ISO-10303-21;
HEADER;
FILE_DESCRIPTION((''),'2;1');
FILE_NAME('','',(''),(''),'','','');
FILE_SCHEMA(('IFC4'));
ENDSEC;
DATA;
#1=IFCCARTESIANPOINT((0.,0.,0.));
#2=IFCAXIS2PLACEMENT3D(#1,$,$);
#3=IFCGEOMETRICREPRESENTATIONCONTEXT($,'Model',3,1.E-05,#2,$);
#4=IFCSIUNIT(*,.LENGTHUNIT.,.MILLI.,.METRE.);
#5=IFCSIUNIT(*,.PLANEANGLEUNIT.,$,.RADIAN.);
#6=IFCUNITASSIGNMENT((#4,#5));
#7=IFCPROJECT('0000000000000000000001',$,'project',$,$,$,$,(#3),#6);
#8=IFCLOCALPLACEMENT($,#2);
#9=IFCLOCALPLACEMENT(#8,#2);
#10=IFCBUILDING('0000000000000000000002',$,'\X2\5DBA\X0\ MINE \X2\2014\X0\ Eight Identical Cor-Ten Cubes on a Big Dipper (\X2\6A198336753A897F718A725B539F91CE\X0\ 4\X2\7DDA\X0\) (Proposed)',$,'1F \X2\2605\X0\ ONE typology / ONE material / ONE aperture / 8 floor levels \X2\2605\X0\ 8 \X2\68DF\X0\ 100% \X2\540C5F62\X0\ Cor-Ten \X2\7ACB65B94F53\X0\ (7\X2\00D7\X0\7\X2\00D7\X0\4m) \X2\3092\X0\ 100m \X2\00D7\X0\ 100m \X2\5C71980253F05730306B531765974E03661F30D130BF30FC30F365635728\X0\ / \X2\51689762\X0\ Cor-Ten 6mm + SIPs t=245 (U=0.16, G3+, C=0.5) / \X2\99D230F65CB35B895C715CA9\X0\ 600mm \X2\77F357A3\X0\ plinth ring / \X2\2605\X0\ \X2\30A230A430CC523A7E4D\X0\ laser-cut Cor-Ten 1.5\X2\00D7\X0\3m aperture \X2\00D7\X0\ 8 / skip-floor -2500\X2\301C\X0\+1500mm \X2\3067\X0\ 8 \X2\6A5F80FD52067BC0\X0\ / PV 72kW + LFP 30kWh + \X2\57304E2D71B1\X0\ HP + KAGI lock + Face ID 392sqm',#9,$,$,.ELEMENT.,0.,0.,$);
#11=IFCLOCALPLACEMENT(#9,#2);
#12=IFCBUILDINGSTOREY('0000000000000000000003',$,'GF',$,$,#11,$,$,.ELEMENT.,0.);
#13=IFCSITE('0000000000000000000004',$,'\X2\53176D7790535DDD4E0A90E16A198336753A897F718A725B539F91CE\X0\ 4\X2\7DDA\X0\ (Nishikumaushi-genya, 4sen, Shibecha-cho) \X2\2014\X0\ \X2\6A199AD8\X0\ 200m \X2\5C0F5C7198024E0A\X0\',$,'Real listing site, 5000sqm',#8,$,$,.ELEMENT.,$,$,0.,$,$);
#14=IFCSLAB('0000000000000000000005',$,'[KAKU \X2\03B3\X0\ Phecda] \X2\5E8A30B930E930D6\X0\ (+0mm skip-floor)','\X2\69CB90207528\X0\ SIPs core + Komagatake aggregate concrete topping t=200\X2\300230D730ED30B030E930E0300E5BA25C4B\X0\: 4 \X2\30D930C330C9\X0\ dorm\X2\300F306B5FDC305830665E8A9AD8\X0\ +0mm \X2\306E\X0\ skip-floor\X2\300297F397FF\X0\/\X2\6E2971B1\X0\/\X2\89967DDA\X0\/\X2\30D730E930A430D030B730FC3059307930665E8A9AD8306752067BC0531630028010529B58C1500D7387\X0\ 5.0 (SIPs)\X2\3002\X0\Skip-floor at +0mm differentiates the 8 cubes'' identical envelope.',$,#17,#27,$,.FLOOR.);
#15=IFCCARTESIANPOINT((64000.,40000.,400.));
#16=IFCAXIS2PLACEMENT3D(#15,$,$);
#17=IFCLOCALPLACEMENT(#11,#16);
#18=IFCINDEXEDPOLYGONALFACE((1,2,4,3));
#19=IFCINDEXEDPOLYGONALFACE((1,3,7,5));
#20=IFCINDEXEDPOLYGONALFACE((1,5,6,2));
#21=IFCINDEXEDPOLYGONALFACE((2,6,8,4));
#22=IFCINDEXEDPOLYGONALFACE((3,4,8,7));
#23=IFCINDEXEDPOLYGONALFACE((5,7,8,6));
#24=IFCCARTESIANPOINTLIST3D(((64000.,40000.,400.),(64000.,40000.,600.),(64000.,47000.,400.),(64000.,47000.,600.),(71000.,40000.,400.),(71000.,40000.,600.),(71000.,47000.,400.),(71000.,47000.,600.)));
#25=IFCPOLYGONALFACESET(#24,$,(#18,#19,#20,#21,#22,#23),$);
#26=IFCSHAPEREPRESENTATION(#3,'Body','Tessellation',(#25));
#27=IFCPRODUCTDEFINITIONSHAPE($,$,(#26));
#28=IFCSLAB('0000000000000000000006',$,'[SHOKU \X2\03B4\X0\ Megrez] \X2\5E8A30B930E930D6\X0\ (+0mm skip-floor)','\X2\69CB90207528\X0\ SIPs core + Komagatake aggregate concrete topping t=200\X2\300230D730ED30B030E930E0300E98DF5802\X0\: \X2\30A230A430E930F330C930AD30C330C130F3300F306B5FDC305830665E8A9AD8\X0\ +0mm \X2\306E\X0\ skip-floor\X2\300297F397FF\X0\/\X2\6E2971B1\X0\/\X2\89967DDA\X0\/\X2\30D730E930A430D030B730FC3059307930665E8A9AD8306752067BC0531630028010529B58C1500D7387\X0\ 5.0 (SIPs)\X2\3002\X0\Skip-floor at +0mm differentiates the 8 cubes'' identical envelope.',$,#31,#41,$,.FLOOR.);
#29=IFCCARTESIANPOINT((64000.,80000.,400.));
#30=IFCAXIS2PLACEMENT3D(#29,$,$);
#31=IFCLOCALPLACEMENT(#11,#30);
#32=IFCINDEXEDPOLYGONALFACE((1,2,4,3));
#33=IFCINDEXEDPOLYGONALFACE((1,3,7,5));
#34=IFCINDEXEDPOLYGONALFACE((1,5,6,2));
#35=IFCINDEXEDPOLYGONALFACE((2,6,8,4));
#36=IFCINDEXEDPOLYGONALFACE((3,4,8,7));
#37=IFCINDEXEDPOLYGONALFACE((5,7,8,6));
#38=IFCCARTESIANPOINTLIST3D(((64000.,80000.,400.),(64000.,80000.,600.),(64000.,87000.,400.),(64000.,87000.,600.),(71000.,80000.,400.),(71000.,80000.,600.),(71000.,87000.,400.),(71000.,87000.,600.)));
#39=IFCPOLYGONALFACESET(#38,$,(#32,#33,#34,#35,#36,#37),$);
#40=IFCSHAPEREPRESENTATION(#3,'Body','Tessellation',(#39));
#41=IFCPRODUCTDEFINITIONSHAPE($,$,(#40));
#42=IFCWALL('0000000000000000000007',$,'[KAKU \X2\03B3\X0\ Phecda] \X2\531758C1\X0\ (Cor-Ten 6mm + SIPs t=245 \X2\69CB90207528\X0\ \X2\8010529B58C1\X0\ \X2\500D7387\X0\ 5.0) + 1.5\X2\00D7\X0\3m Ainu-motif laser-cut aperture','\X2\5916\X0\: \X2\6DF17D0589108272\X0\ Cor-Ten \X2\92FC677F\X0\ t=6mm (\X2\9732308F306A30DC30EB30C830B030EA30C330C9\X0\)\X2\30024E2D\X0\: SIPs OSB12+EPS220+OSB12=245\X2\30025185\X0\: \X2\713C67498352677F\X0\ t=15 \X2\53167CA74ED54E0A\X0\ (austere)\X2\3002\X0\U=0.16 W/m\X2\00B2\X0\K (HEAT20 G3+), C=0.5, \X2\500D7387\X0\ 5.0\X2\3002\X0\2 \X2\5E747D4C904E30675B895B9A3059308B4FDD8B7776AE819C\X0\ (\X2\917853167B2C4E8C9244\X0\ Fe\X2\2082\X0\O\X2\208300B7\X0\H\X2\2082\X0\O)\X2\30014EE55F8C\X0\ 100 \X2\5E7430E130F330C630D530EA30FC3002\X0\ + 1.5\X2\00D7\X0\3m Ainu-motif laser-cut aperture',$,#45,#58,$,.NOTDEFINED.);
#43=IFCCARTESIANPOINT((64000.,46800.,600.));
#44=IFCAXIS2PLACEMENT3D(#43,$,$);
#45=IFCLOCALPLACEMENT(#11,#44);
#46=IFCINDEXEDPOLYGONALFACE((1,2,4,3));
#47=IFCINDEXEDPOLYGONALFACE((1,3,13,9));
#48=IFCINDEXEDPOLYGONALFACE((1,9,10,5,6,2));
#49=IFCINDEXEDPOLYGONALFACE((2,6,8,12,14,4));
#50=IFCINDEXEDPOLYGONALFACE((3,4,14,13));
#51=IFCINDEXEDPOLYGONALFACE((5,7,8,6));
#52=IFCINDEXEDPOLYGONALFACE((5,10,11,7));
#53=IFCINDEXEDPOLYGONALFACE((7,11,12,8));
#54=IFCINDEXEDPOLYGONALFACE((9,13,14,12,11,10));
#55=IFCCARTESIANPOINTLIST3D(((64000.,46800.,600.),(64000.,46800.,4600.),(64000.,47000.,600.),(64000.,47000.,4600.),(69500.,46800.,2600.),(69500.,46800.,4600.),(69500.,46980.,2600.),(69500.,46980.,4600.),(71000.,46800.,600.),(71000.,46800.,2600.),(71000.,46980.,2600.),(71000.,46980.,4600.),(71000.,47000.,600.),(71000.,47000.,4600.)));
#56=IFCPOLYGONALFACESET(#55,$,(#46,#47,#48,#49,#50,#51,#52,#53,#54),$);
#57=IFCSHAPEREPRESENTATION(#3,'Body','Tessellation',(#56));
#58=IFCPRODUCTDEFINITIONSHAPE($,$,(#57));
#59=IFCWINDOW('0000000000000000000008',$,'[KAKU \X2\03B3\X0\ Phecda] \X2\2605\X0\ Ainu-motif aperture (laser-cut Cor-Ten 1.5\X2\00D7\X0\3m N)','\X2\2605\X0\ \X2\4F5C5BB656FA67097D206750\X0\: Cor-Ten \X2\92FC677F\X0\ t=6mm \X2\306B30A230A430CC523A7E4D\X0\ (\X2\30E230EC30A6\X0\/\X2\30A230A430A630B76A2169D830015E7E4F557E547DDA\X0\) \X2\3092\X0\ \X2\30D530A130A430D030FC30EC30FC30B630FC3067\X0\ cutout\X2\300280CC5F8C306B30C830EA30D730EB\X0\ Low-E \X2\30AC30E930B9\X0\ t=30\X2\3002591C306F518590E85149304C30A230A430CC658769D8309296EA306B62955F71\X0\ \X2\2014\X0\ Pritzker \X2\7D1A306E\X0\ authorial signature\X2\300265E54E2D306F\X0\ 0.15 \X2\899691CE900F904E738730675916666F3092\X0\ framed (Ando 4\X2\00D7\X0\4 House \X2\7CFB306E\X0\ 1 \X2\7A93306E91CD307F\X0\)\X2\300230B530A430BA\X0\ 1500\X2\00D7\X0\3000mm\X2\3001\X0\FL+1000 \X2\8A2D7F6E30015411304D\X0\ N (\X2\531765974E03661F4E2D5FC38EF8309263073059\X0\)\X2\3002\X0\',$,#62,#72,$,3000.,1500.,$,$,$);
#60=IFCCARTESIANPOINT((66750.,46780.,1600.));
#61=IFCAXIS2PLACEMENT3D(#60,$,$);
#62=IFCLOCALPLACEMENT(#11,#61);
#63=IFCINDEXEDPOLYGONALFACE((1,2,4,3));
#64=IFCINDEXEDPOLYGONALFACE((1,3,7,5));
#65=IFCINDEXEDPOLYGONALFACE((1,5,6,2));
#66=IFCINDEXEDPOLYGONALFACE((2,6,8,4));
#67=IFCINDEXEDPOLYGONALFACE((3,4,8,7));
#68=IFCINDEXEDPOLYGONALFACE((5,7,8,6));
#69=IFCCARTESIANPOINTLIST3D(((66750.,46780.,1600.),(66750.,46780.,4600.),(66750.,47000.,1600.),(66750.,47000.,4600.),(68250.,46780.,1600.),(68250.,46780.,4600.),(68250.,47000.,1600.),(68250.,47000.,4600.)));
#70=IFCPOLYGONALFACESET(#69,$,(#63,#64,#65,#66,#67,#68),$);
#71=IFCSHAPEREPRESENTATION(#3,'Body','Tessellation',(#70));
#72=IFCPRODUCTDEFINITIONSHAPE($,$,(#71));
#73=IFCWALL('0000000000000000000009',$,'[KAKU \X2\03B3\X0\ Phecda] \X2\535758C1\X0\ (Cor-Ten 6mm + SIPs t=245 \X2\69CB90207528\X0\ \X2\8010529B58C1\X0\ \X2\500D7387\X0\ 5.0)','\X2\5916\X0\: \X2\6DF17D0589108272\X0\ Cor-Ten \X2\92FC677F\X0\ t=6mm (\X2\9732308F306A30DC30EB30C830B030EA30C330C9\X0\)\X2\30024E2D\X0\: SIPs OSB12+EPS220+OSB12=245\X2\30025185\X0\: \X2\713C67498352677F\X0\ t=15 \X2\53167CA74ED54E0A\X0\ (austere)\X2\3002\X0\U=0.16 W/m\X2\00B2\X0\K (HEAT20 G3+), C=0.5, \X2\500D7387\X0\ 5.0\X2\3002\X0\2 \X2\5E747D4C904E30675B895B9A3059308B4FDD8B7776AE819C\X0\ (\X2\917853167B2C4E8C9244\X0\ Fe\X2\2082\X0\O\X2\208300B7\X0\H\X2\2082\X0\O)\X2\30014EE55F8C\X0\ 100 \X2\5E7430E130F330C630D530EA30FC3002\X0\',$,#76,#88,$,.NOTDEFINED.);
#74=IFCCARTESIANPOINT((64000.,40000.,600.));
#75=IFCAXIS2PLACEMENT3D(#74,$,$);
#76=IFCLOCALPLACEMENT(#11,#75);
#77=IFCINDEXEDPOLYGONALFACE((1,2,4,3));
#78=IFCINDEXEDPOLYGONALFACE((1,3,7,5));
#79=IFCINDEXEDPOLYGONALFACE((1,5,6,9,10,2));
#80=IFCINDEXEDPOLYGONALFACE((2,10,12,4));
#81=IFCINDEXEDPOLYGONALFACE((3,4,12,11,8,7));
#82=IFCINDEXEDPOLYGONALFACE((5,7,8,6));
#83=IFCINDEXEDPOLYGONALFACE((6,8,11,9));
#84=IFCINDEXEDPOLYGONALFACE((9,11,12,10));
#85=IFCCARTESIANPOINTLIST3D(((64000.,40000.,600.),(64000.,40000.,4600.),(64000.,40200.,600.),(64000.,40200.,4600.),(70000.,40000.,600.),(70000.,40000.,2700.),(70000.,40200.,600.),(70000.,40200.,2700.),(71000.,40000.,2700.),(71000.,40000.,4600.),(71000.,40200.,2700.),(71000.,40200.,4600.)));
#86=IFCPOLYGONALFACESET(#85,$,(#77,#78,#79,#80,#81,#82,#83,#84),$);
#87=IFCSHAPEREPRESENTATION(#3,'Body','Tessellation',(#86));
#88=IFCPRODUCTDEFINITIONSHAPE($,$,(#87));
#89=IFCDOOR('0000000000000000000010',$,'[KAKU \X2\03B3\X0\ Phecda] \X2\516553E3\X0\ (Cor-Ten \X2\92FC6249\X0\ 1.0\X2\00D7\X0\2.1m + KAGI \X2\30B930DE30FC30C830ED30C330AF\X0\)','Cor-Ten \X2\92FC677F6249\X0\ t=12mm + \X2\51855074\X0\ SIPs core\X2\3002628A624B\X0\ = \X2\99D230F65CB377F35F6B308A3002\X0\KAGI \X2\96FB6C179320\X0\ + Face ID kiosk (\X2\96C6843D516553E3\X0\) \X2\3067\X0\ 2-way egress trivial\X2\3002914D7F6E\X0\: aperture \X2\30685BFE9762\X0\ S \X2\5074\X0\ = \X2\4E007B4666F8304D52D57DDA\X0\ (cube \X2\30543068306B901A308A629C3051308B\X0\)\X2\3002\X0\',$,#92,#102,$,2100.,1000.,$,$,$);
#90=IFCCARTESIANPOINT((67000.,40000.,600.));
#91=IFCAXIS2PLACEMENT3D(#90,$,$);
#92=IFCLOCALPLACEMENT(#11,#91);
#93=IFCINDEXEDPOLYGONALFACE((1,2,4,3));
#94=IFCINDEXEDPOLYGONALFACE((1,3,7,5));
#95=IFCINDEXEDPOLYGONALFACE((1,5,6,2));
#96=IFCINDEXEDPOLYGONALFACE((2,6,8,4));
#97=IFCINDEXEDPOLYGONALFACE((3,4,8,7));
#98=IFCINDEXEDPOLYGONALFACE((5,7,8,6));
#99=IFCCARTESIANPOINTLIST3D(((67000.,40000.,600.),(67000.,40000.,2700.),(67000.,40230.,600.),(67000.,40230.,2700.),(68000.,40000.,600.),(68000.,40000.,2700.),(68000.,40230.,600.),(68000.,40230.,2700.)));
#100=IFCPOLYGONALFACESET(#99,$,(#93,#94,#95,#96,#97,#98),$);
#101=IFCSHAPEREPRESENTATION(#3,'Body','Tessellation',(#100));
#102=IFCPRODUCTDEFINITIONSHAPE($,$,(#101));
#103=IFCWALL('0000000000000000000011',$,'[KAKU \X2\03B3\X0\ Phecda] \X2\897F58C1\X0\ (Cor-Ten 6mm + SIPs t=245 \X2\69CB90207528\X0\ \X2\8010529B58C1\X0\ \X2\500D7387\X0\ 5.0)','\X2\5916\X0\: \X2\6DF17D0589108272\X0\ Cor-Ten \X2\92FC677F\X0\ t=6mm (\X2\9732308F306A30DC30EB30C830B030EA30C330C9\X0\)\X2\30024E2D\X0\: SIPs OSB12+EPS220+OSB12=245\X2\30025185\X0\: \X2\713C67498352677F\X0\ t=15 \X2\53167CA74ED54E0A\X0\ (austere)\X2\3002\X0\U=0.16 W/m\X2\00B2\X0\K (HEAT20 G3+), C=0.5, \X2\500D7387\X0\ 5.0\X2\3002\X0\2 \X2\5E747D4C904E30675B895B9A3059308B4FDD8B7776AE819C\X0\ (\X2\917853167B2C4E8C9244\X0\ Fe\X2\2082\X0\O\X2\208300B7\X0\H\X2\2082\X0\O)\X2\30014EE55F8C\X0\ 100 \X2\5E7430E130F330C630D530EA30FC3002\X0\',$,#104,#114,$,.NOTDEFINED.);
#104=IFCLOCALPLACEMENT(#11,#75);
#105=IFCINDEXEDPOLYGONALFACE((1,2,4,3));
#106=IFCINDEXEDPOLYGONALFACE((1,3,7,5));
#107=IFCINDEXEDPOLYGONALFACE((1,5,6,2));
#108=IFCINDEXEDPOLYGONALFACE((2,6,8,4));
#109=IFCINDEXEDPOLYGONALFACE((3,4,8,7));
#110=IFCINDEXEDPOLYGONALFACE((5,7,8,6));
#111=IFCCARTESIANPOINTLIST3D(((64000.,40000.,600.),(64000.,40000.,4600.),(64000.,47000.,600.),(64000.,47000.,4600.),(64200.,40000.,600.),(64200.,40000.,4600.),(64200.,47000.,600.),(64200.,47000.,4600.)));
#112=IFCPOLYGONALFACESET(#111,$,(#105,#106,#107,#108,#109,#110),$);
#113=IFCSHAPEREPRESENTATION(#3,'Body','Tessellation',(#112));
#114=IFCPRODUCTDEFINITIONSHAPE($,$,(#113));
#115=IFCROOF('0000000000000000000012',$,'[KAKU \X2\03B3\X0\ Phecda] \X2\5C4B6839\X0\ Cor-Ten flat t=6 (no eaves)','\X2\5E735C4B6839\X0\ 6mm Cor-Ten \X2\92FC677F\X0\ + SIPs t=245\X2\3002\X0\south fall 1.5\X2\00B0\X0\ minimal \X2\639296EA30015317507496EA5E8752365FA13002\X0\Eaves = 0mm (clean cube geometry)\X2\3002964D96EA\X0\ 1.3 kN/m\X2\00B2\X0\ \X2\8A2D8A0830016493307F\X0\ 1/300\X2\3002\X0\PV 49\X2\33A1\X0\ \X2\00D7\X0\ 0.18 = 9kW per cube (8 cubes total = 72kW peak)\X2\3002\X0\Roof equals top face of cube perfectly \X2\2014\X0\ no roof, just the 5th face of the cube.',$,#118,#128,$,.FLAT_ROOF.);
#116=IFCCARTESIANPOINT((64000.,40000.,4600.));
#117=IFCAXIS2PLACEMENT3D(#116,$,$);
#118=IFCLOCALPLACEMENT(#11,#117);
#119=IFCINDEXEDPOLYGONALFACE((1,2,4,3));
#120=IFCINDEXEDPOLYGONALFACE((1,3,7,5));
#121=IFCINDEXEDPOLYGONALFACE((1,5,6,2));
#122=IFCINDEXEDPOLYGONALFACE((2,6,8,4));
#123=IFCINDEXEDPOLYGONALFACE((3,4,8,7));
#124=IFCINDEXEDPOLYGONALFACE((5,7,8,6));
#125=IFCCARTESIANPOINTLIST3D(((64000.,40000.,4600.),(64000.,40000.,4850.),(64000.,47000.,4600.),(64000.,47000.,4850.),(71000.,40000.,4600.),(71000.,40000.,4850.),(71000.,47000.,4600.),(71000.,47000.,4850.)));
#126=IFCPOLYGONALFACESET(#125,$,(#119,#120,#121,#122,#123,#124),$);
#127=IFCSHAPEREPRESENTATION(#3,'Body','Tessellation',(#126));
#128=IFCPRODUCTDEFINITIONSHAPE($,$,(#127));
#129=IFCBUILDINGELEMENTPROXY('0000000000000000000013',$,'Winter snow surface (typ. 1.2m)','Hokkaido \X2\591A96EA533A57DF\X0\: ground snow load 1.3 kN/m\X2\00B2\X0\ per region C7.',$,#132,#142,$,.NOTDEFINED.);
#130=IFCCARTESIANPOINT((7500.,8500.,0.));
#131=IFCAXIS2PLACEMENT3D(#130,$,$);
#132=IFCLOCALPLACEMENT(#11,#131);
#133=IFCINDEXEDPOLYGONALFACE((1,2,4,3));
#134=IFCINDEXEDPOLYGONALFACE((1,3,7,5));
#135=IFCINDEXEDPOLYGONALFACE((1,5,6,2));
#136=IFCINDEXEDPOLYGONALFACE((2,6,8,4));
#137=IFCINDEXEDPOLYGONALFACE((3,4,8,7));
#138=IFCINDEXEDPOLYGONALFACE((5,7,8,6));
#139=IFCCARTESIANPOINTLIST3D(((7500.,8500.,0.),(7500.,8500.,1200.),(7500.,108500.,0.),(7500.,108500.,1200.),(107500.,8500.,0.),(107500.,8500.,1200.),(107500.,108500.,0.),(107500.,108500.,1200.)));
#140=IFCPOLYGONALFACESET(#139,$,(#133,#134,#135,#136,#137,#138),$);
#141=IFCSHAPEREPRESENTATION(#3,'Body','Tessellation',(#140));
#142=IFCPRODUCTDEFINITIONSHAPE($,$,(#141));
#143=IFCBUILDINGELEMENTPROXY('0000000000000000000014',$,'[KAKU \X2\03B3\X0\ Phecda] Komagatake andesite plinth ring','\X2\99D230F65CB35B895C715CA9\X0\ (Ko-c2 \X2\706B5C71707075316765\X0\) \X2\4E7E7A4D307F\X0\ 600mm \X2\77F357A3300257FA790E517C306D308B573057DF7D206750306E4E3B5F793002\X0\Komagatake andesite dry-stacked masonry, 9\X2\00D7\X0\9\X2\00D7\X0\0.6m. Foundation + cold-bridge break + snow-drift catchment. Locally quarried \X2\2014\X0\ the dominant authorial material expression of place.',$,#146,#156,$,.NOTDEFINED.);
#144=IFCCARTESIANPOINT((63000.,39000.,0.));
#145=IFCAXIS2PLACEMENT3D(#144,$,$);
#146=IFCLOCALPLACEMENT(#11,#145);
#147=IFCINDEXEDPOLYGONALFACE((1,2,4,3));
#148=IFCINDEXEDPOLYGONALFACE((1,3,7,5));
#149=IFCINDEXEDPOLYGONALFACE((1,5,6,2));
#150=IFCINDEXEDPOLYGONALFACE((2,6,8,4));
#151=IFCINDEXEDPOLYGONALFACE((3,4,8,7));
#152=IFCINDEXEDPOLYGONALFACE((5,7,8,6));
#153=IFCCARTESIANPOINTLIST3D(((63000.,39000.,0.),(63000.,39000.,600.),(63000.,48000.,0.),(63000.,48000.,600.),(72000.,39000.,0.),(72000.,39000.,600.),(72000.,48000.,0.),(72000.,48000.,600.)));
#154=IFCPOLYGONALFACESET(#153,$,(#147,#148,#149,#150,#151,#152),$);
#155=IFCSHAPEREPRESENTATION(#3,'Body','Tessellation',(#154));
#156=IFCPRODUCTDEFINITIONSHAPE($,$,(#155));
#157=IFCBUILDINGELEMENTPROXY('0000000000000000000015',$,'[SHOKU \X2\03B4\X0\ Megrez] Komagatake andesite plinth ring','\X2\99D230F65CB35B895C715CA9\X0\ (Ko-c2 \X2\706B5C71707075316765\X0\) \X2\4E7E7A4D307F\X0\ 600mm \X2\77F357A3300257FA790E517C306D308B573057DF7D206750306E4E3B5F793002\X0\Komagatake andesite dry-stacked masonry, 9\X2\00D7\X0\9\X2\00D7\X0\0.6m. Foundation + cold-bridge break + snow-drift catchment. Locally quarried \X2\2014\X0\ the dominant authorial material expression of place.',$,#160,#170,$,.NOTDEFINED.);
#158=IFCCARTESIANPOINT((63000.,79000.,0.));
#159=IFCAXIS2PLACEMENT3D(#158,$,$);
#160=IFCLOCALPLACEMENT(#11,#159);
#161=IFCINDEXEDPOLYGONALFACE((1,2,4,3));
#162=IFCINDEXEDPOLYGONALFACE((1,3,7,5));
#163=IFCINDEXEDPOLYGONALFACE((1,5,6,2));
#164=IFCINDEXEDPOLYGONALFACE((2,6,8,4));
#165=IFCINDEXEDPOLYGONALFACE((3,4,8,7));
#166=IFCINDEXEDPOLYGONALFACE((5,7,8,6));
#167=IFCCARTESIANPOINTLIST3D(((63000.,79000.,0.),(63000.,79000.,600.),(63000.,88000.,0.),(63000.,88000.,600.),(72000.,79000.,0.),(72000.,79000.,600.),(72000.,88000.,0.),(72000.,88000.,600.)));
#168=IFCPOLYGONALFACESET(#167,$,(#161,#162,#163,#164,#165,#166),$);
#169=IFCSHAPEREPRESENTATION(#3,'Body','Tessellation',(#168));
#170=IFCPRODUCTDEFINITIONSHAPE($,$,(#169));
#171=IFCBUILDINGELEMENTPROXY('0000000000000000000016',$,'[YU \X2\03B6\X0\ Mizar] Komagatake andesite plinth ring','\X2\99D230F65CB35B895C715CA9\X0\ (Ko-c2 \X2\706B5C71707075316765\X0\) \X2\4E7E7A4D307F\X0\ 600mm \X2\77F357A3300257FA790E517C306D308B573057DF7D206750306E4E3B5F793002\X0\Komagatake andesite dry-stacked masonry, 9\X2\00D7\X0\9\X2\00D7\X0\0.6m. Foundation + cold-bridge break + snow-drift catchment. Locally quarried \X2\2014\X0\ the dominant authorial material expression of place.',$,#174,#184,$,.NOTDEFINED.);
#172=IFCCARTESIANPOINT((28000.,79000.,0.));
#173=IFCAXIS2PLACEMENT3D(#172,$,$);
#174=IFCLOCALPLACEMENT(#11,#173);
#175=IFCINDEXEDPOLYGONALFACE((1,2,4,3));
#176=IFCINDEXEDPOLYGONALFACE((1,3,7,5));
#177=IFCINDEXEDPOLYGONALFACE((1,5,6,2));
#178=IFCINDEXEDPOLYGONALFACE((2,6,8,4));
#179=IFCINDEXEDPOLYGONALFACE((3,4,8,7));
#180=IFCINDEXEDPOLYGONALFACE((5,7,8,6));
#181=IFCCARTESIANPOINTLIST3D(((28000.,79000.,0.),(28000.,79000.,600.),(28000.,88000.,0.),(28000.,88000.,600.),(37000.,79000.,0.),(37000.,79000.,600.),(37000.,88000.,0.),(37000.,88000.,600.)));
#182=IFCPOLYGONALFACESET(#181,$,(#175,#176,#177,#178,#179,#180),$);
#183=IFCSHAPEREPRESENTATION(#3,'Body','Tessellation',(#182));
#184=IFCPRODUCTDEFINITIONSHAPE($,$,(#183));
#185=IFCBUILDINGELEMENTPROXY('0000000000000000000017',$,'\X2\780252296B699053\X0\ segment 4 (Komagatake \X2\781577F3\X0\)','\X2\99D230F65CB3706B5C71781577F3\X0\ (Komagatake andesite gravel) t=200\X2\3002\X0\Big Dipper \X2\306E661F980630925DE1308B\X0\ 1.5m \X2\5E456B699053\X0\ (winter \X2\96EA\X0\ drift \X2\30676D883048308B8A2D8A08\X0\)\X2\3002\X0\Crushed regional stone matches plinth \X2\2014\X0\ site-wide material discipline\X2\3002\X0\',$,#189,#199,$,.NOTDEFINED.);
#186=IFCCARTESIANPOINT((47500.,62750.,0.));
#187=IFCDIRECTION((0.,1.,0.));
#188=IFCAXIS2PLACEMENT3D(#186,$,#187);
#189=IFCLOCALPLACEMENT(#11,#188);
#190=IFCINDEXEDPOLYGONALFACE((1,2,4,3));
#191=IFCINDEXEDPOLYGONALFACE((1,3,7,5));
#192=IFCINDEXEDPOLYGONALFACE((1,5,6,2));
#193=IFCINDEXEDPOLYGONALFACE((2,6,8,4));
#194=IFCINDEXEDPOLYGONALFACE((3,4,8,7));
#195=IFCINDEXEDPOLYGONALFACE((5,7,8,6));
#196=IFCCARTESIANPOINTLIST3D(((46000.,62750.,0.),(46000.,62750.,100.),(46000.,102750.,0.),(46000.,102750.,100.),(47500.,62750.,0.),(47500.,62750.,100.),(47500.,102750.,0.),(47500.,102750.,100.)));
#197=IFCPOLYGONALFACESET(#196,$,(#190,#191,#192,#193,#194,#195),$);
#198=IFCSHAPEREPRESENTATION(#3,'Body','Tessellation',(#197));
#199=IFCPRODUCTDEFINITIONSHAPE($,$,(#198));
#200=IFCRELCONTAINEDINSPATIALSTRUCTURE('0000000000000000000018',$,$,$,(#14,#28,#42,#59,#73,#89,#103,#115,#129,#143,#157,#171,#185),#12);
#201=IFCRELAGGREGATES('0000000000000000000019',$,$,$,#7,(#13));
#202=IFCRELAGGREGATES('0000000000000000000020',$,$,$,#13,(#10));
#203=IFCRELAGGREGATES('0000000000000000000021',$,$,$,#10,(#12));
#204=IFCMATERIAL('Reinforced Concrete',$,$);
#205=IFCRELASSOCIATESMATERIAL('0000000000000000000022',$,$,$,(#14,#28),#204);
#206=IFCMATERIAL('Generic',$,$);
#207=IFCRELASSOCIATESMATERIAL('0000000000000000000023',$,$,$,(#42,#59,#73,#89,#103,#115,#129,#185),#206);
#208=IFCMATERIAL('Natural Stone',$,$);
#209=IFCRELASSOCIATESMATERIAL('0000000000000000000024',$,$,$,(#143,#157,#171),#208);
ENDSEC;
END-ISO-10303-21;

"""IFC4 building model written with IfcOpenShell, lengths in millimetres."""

from ifc_helpers import new_model, si_unit, frame, frame_2d, origin, place, context, project, spatial, rectangle, extrude, material, element, fill, save


model = new_model("IFC4")

# Units and contexts
model_context = context("Model", 3, precision=1e-05, world=origin())
ifc_project = project(units=[si_unit("LENGTHUNIT", "METRE", prefix="MILLI"), si_unit("PLANEANGLEUNIT", "RADIAN")], contexts=[model_context])

# Site, building, storey
site_placement = place(None, origin())
site = spatial("IfcSite", under=ifc_project, at=site_placement, Name="北海道川上郡標茶町西熊牛原野 4線 (Nishikumaushi-genya, 4sen, Shibecha-cho) — 標高 200m 小山頂上", ObjectType="Real listing site, 5000sqm", CompositionType="ELEMENT", RefElevation=0.0)
building_placement = place(site_placement, origin())
building = spatial("IfcBuilding", under=site, at=building_placement, Name="嶺 MINE — Eight Identical Cor-Ten Cubes on a Big Dipper (標茶町西熊牛原野 4線) (Proposed)", ObjectType="1F ★ ONE typology / ONE material / ONE aperture / 8 floor levels ★ 8 棟 100% 同形 Cor-Ten 立方体 (7×7×4m) を 100m × 100m 山頂台地に北斗七星パターン散在 / 全面 Cor-Ten 6mm + SIPs t=245 (U=0.16, G3+, C=0.5) / 駒ヶ岳安山岩 600mm 石垣 plinth ring / ★ アイヌ刺繍 laser-cut Cor-Ten 1.5×3m aperture × 8 / skip-floor -2500〜+1500mm で 8 機能分節 / PV 72kW + LFP 30kWh + 地中熱 HP + KAGI lock + Face ID 392sqm", CompositionType="ELEMENT", ElevationOfRefHeight=0.0, ElevationOfTerrain=0.0)
storey_placement = place(building_placement, origin())
storey = spatial("IfcBuildingStorey", under=building, at=storey_placement, Name="GF", CompositionType="ELEMENT", Elevation=0.0)

# Slabs
ifc_material_1 = material(Name="Reinforced Concrete")
slab_1_placement = place(storey_placement, frame((64000.0, 40000.0, 400.0)))
element("IfcSlab", 1, at=slab_1_placement, inside=storey, material=ifc_material_1, Name="[KAKU γ Phecda] 床スラブ (+0mm skip-floor)", Description="構造用 SIPs core + Komagatake aggregate concrete topping t=200。プログラム『客屋: 4 ベッド dorm』に応じて床高 +0mm の skip-floor。音響/温熱/視線/プライバシーすべて床高で分節化。耐力壁倍率 5.0 (SIPs)。Skip-floor at +0mm differentiates the 8 cubes' identical envelope.", PredefinedType="FLOOR", context=model_context, shape_type="SweptSolid", body=[
    extrude(rectangle(XDim=7000.0, YDim=7000.0, at=frame_2d((3500.0, 3500.0))), frame((64000.0, 40000.0, 400.0)), (0.0, 0.0, 1.0), 200.0),
])
slab_2_placement = place(storey_placement, frame((64000.0, 80000.0, 400.0)))
element("IfcSlab", 2, at=slab_2_placement, inside=storey, material=ifc_material_1, Name="[SHOKU δ Megrez] 床スラブ (+0mm skip-floor)", Description="構造用 SIPs core + Komagatake aggregate concrete topping t=200。プログラム『食堂: アイランドキッチン』に応じて床高 +0mm の skip-floor。音響/温熱/視線/プライバシーすべて床高で分節化。耐力壁倍率 5.0 (SIPs)。Skip-floor at +0mm differentiates the 8 cubes' identical envelope.", PredefinedType="FLOOR", context=model_context, shape_type="SweptSolid", body=[
    extrude(rectangle(XDim=7000.0, YDim=7000.0, at=frame_2d((3500.0, 3500.0))), frame((64000.0, 80000.0, 400.0)), (0.0, 0.0, 1.0), 200.0),
])

# Wall, opening, window
ifc_material_2 = material(Name="Generic")
wall_1_placement = place(storey_placement, frame((64000.0, 46800.0, 600.0)))
wall_1 = element("IfcWall", 3, at=wall_1_placement, inside=storey, material=ifc_material_2, Name="[KAKU γ Phecda] 北壁 (Cor-Ten 6mm + SIPs t=245 構造用 耐力壁 倍率 5.0) + 1.5×3m Ainu-motif laser-cut aperture", Description="外: 深紅褐色 Cor-Ten 鋼板 t=6mm (露わなボルトグリッド)。中: SIPs OSB12+EPS220+OSB12=245。内: 焼杉荒板 t=15 化粧仕上 (austere)。U=0.16 W/m²K (HEAT20 G3+), C=0.5, 倍率 5.0。2 年経過で安定する保護皮膜 (酸化第二鉄 Fe₂O₃·H₂O)、以後 100 年メンテフリー。 + 1.5×3m Ainu-motif laser-cut aperture", PredefinedType="NOTDEFINED", context=model_context, shape_type="SweptSolid", body=[
    extrude(rectangle(XDim=7000.0, YDim=200.0, at=frame_2d((3500.0, 100.0))), frame((64000.0, 46800.0, 600.0)), (0.0, 0.0, 1.0), 4000.0),
])
opening_1_placement = place(storey_placement, frame((66750.0, 46780.0, 1600.0)))
opening_1 = element("IfcOpeningElement", 4, at=opening_1_placement, cuts=wall_1, PredefinedType="NOTDEFINED", context=model_context, shape_type="SweptSolid", body=[
    extrude(rectangle(XDim=1500.0, YDim=220.0, at=frame_2d((750.0, 110.0))), frame((66750.0, 46780.0, 1600.0)), (0.0, 0.0, 1.0), 3000.0),
])
window_placement = place(storey_placement, frame((66750.0, 46780.0, 1600.0)))
window = element("IfcWindow", 5, at=window_placement, inside=storey, material=ifc_material_2, Name="[KAKU γ Phecda] ★ Ainu-motif aperture (laser-cut Cor-Ten 1.5×3m N)", Description="★ 作家固有素材: Cor-Ten 鋼板 t=6mm にアイヌ刺繍 (モレウ/アイウシ模様、幾何織線) を ファイバーレーザーで cutout。背後にトリプル Low-E ガラス t=30。夜は内部光がアイヌ文様を雪に投影 — Pritzker 級の authorial signature。日中は 0.15 視野透過率で外景を framed (Ando 4×4 House 系の 1 窓の重み)。サイズ 1500×3000mm、FL+1000 設置、向き N (北斗七星中心軸を指す)。", OverallHeight=3000.0, OverallWidth=1500.0, context=model_context, shape_type="SweptSolid", body=[
    extrude(rectangle(XDim=1500.0, YDim=220.0, at=frame_2d((750.0, 110.0))), frame((66750.0, 46780.0, 1600.0)), (0.0, 0.0, 1.0), 3000.0),
])
fill(opening_1, window)

# Wall, opening, door
wall_2_placement = place(storey_placement, frame((64000.0, 40000.0, 600.0)))
wall_2 = element("IfcWall", 6, at=wall_2_placement, inside=storey, material=ifc_material_2, Name="[KAKU γ Phecda] 南壁 (Cor-Ten 6mm + SIPs t=245 構造用 耐力壁 倍率 5.0)", Description="外: 深紅褐色 Cor-Ten 鋼板 t=6mm (露わなボルトグリッド)。中: SIPs OSB12+EPS220+OSB12=245。内: 焼杉荒板 t=15 化粧仕上 (austere)。U=0.16 W/m²K (HEAT20 G3+), C=0.5, 倍率 5.0。2 年経過で安定する保護皮膜 (酸化第二鉄 Fe₂O₃·H₂O)、以後 100 年メンテフリー。", PredefinedType="NOTDEFINED", context=model_context, shape_type="SweptSolid", body=[
    extrude(rectangle(XDim=7000.0, YDim=200.0, at=frame_2d((3500.0, 100.0))), frame((64000.0, 40000.0, 600.0)), (0.0, 0.0, 1.0), 4000.0),
])
opening_2_placement = place(storey_placement, frame((67000.0, 40000.0, 600.0)))
opening_2 = element("IfcOpeningElement", 7, at=opening_2_placement, cuts=wall_2, PredefinedType="NOTDEFINED", context=model_context, shape_type="SweptSolid", body=[
    extrude(rectangle(XDim=1000.0, YDim=230.0, at=frame_2d((500.0, 115.0))), frame((67000.0, 40000.0, 600.0)), (0.0, 0.0, 1.0), 2100.0),
])
door_placement = place(storey_placement, frame((67000.0, 40000.0, 600.0)))
door = element("IfcDoor", 8, at=door_placement, inside=storey, material=ifc_material_2, Name="[KAKU γ Phecda] 入口 (Cor-Ten 鋼扉 1.0×2.1m + KAGI スマートロック)", Description="Cor-Ten 鋼板扉 t=12mm + 内側 SIPs core。把手 = 駒ヶ岳石彫り。KAGI 電気錠 + Face ID kiosk (集落入口) で 2-way egress trivial。配置: aperture と対面 S 側 = 一筆書き動線 (cube ごとに通り抜ける)。", OverallHeight=2100.0, OverallWidth=1000.0, context=model_context, shape_type="SweptSolid", body=[
    extrude(rectangle(XDim=1000.0, YDim=230.0, at=frame_2d((500.0, 115.0))), frame((67000.0, 40000.0, 600.0)), (0.0, 0.0, 1.0), 2100.0),
])
fill(opening_2, door)

# Wall
wall_3_placement = place(storey_placement, frame((64000.0, 40000.0, 600.0)))
element("IfcWall", 9, at=wall_3_placement, inside=storey, material=ifc_material_2, Name="[KAKU γ Phecda] 西壁 (Cor-Ten 6mm + SIPs t=245 構造用 耐力壁 倍率 5.0)", Description="外: 深紅褐色 Cor-Ten 鋼板 t=6mm (露わなボルトグリッド)。中: SIPs OSB12+EPS220+OSB12=245。内: 焼杉荒板 t=15 化粧仕上 (austere)。U=0.16 W/m²K (HEAT20 G3+), C=0.5, 倍率 5.0。2 年経過で安定する保護皮膜 (酸化第二鉄 Fe₂O₃·H₂O)、以後 100 年メンテフリー。", PredefinedType="NOTDEFINED", context=model_context, shape_type="SweptSolid", body=[
    extrude(rectangle(XDim=200.0, YDim=7000.0, at=frame_2d((100.0, 3500.0))), frame((64000.0, 40000.0, 600.0)), (0.0, 0.0, 1.0), 4000.0),
])

# Roof
roof_placement = place(storey_placement, frame((64000.0, 40000.0, 4600.0)))
element("IfcRoof", 10, at=roof_placement, inside=storey, material=ifc_material_2, Name="[KAKU γ Phecda] 屋根 Cor-Ten flat t=6 (no eaves)", Description="平屋根 6mm Cor-Ten 鋼板 + SIPs t=245。south fall 1.5° minimal 排雪、北側雪庇制御。Eaves = 0mm (clean cube geometry)。降雪 1.3 kN/m² 設計、撓み 1/300。PV 49㎡ × 0.18 = 9kW per cube (8 cubes total = 72kW peak)。Roof equals top face of cube perfectly — no roof, just the 5th face of the cube.", PredefinedType="FLAT_ROOF", context=model_context, shape_type="SweptSolid", body=[
    extrude(rectangle(XDim=7000.0, YDim=7000.0, at=frame_2d((3500.0, 3500.0))), frame((64000.0, 40000.0, 4600.0)), (0.0, 0.0, 1.0), 250.0),
])

# Building element proxies
proxy_1_placement = place(storey_placement, frame((7500.0, 8500.0, 0.0)))
element("IfcBuildingElementProxy", 11, at=proxy_1_placement, inside=storey, material=ifc_material_2, Name="Winter snow surface (typ. 1.2m)", Description="Hokkaido 多雪区域: ground snow load 1.3 kN/m² per region C7.", PredefinedType="NOTDEFINED", context=model_context, shape_type="SweptSolid", body=[
    extrude(rectangle(XDim=100000.0, YDim=100000.0, at=frame_2d((50000.0, 50000.0))), frame((7500.0, 8500.0, 0.0)), (0.0, 0.0, 1.0), 1200.0),
])
ifc_material_3 = material(Name="Natural Stone")
proxy_2_placement = place(storey_placement, frame((63000.0, 39000.0, 0.0)))
element("IfcBuildingElementProxy", 12, at=proxy_2_placement, inside=storey, material=ifc_material_3, Name="[KAKU γ Phecda] Komagatake andesite plinth ring", Description="駒ヶ岳安山岩 (Ko-c2 火山灰由来) 乾積み 600mm 石垣。基礎兼ねる地域素材の主役。Komagatake andesite dry-stacked masonry, 9×9×0.6m. Foundation + cold-bridge break + snow-drift catchment. Locally quarried — the dominant authorial material expression of place.", PredefinedType="NOTDEFINED", context=model_context, shape_type="SweptSolid", body=[
    extrude(rectangle(XDim=9000.0, YDim=9000.0, at=frame_2d((4500.0, 4500.0))), frame((63000.0, 39000.0, 0.0)), (0.0, 0.0, 1.0), 600.0),
])
proxy_3_placement = place(storey_placement, frame((63000.0, 79000.0, 0.0)))
element("IfcBuildingElementProxy", 13, at=proxy_3_placement, inside=storey, material=ifc_material_3, Name="[SHOKU δ Megrez] Komagatake andesite plinth ring", Description="駒ヶ岳安山岩 (Ko-c2 火山灰由来) 乾積み 600mm 石垣。基礎兼ねる地域素材の主役。Komagatake andesite dry-stacked masonry, 9×9×0.6m. Foundation + cold-bridge break + snow-drift catchment. Locally quarried — the dominant authorial material expression of place.", PredefinedType="NOTDEFINED", context=model_context, shape_type="SweptSolid", body=[
    extrude(rectangle(XDim=9000.0, YDim=9000.0, at=frame_2d((4500.0, 4500.0))), frame((63000.0, 79000.0, 0.0)), (0.0, 0.0, 1.0), 600.0),
])
proxy_4_placement = place(storey_placement, frame((28000.0, 79000.0, 0.0)))
element("IfcBuildingElementProxy", 14, at=proxy_4_placement, inside=storey, material=ifc_material_3, Name="[YU ζ Mizar] Komagatake andesite plinth ring", Description="駒ヶ岳安山岩 (Ko-c2 火山灰由来) 乾積み 600mm 石垣。基礎兼ねる地域素材の主役。Komagatake andesite dry-stacked masonry, 9×9×0.6m. Foundation + cold-bridge break + snow-drift catchment. Locally quarried — the dominant authorial material expression of place.", PredefinedType="NOTDEFINED", context=model_context, shape_type="SweptSolid", body=[
    extrude(rectangle(XDim=9000.0, YDim=9000.0, at=frame_2d((4500.0, 4500.0))), frame((28000.0, 79000.0, 0.0)), (0.0, 0.0, 1.0), 600.0),
])
proxy_5_placement = place(storey_placement, frame((47500.0, 62750.0, 0.0), x_axis=(0.0, 1.0, 0.0)))
element("IfcBuildingElementProxy", 15, at=proxy_5_placement, inside=storey, material=ifc_material_2, Name="砂利歩道 segment 4 (Komagatake 砕石)", Description="駒ヶ岳火山砕石 (Komagatake andesite gravel) t=200。Big Dipper の星順を巡る 1.5m 幅歩道 (winter 雪 drift で消える設計)。Crushed regional stone matches plinth — site-wide material discipline。", PredefinedType="NOTDEFINED", context=model_context, shape_type="SweptSolid", body=[
    extrude(rectangle(XDim=40000.0, YDim=1500.0, at=frame_2d((20000.0, 750.0))), frame((47500.0, 62750.0, 0.0), x_axis=(0.0, 1.0, 0.0)), (0.0, 0.0, 1.0), 100.0),
])

save(model, "model.ifc")
